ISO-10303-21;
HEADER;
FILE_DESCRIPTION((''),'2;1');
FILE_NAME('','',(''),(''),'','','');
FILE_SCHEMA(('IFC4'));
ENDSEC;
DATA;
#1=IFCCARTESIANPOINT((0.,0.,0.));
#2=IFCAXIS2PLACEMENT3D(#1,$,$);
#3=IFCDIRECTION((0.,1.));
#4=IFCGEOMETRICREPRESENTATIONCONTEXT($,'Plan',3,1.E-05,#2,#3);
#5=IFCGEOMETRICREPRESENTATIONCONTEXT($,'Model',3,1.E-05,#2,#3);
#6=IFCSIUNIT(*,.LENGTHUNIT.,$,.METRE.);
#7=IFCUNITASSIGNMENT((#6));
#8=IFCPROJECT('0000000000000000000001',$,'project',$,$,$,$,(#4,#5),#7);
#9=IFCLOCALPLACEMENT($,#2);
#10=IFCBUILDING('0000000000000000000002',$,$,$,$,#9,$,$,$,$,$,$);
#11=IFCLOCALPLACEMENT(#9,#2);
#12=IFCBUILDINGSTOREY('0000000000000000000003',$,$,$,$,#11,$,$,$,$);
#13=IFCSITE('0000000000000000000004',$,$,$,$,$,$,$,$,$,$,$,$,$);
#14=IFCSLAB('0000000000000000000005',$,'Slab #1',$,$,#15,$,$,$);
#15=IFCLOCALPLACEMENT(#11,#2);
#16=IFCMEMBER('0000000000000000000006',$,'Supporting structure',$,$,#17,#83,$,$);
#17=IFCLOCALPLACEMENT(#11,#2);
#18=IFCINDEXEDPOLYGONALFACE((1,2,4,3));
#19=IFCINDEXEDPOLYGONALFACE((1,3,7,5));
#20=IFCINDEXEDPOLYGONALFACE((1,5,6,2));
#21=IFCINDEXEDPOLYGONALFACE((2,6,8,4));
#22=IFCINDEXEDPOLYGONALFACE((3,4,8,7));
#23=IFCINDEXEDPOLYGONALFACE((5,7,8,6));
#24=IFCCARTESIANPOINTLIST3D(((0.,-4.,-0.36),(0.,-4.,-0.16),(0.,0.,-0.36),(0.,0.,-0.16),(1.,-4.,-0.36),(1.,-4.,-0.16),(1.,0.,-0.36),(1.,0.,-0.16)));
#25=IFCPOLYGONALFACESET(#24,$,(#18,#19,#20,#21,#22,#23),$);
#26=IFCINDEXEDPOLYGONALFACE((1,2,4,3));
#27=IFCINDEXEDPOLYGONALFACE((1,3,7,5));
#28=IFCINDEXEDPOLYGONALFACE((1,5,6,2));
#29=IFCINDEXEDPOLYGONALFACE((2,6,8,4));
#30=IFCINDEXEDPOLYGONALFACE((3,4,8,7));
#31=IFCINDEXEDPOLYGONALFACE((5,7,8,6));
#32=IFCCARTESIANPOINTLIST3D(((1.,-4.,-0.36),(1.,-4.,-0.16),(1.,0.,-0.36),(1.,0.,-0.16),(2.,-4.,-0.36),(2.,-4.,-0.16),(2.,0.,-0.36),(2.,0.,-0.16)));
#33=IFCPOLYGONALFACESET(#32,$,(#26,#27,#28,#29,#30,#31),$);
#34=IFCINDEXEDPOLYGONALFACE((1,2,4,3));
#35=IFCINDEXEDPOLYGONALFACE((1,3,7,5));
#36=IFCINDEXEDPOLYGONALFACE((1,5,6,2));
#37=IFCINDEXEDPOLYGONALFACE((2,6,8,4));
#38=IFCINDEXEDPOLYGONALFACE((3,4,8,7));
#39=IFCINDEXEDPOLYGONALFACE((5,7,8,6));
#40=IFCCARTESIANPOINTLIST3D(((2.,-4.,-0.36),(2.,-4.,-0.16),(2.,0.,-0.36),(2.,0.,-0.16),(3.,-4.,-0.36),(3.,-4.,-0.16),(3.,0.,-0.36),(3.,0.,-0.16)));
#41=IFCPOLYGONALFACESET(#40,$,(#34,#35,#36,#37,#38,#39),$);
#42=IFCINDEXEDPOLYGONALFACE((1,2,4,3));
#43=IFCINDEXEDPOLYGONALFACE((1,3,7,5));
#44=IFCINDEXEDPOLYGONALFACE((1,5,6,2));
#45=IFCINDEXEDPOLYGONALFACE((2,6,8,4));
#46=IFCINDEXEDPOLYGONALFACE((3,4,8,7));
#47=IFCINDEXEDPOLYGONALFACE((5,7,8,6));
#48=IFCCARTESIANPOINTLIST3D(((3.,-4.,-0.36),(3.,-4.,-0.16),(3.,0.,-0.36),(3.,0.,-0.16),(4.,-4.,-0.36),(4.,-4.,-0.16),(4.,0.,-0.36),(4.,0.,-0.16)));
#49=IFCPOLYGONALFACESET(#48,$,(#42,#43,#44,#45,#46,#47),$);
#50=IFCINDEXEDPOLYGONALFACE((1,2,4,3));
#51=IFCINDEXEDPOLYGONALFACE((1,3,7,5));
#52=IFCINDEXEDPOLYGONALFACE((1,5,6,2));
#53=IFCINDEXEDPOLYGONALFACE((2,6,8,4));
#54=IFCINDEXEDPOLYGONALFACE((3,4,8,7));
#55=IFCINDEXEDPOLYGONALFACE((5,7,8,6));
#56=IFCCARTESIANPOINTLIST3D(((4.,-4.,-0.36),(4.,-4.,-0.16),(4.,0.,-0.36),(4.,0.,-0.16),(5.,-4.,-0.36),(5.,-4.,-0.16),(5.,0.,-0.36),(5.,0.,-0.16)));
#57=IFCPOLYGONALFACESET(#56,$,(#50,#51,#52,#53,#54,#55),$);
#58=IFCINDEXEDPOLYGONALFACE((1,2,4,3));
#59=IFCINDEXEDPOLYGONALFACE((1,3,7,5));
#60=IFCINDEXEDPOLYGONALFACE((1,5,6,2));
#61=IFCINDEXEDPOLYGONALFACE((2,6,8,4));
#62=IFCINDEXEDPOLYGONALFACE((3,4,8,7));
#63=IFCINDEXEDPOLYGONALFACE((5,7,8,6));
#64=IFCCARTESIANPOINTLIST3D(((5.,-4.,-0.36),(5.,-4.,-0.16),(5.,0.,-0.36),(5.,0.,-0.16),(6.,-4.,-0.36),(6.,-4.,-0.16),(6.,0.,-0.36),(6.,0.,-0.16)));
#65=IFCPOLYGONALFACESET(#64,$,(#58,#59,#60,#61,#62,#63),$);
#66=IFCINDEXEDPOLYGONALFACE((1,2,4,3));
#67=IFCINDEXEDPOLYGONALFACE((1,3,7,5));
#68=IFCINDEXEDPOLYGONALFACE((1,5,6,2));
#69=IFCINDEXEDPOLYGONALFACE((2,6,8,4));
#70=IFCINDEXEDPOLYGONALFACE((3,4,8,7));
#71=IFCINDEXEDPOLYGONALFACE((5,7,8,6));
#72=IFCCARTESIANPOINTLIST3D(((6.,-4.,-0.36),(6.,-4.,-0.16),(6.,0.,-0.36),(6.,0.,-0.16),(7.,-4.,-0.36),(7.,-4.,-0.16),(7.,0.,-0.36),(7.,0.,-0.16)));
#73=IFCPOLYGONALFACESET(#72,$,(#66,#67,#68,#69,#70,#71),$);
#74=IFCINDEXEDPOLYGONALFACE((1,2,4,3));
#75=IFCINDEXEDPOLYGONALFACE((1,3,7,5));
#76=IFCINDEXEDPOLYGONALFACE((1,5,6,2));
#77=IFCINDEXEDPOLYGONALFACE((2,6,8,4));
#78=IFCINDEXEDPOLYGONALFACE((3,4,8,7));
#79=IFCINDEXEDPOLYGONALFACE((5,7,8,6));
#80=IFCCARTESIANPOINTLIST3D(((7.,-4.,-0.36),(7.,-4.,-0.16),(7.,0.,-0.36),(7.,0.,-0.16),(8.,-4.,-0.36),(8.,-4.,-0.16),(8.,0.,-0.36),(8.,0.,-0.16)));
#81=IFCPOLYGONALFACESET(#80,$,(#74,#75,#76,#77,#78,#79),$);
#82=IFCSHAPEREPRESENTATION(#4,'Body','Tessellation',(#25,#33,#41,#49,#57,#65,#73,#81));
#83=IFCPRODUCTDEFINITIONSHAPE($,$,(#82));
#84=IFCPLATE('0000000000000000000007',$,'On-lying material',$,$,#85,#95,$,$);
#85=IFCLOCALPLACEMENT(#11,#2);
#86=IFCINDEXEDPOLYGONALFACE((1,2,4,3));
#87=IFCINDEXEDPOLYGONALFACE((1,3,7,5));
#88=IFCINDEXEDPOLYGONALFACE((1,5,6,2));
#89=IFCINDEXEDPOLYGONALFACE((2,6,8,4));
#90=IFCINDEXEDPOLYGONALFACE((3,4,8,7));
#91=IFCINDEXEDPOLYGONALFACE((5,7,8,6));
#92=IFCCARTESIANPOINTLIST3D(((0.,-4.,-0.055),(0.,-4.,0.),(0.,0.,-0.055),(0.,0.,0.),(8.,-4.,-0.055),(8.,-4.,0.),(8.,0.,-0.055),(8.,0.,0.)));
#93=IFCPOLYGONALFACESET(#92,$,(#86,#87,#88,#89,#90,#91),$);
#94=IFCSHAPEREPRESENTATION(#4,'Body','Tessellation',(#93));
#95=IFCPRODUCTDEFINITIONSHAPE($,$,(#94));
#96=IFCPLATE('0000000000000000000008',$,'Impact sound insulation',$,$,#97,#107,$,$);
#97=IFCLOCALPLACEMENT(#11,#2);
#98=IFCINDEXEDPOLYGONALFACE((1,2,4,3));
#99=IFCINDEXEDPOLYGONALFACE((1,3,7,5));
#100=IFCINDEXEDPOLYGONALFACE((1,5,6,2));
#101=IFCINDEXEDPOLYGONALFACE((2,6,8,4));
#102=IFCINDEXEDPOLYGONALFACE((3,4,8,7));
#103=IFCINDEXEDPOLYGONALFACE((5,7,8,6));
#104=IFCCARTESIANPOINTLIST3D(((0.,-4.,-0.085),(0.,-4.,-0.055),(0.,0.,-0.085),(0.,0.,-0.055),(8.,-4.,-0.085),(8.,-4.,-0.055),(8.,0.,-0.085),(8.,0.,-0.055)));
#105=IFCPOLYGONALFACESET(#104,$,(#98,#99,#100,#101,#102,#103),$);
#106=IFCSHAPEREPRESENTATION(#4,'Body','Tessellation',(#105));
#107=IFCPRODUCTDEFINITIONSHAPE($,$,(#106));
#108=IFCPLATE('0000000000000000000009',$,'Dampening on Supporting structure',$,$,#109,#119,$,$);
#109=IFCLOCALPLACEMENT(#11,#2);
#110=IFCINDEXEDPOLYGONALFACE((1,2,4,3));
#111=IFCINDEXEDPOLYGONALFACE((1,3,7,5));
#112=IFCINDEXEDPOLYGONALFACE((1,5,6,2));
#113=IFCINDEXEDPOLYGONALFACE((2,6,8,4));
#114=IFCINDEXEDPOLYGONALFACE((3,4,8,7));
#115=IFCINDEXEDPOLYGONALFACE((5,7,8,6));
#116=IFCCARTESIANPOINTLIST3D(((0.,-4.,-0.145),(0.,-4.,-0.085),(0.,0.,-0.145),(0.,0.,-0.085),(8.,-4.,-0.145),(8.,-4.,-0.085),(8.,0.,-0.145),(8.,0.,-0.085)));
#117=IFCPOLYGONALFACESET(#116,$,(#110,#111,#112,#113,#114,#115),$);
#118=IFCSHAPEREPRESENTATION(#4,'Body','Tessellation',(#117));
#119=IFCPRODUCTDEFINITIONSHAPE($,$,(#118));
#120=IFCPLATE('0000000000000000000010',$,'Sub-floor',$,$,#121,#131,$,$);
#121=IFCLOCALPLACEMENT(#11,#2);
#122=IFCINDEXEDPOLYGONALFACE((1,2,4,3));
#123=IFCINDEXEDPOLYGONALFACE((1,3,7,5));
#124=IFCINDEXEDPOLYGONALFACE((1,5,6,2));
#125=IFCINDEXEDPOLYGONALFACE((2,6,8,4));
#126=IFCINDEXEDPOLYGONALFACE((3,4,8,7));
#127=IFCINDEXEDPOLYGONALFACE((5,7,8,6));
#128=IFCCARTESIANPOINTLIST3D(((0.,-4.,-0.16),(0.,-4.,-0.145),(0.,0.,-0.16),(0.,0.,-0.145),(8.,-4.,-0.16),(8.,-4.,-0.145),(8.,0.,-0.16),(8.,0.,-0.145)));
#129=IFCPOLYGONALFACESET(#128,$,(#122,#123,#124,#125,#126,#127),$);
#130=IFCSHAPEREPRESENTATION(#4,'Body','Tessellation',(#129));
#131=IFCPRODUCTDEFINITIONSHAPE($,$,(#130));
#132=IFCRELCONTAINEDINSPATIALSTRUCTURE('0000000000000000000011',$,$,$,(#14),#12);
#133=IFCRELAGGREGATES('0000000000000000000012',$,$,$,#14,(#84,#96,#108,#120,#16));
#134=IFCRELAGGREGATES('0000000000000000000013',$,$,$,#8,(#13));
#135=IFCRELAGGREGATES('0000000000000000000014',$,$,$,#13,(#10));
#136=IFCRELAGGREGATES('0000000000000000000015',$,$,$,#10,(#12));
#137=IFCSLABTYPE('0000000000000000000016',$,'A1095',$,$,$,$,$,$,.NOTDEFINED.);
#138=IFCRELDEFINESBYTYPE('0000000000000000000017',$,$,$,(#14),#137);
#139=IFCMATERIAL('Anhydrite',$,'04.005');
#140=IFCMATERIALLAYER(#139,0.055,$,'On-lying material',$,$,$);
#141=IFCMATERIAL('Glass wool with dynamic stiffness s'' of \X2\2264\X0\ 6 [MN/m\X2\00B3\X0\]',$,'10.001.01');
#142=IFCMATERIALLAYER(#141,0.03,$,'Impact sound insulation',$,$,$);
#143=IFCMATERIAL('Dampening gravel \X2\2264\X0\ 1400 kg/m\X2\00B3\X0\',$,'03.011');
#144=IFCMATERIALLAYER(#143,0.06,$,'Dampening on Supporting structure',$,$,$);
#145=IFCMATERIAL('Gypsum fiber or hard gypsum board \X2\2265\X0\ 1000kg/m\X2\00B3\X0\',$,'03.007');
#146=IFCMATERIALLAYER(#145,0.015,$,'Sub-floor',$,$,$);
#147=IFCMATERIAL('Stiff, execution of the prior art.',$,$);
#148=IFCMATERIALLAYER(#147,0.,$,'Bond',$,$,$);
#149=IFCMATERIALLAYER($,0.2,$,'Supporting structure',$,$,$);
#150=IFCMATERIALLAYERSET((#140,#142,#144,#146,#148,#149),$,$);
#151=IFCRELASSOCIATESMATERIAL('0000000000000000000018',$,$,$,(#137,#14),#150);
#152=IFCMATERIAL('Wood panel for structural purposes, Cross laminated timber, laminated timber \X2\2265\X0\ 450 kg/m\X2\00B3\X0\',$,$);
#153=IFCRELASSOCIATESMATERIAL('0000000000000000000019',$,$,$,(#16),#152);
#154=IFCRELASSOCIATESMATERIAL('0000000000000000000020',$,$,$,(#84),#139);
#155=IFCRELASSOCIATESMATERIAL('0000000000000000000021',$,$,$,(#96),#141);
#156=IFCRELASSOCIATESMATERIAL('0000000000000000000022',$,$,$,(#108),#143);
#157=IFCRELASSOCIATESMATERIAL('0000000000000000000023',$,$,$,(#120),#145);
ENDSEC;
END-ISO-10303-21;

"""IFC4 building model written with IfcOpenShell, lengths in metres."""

from ifc_helpers import new_model, si_unit, direction, frame, frame_2d, origin, origin_with_axes, place, context, project, spatial, rectangle, extrude, material, layer, layer_set, type_object, element, aggregate, save


model = new_model("IFC4")

# Units and contexts
plan_context = context("Plan", 3, precision=1e-05, world=origin(), true_north=direction((0.0, 1.0)))
model_context = context("Model", 3, precision=1e-05, world=origin(), true_north=direction((0.0, 1.0)))
ifc_project = project(units=[si_unit("LENGTHUNIT", "METRE")], contexts=[plan_context, model_context])

# Site, building, storey
site = spatial("IfcSite", under=ifc_project)
building_placement = place(None, origin())
building = spatial("IfcBuilding", under=site, at=building_placement)
storey_placement = place(building_placement, origin())
storey = spatial("IfcBuildingStorey", under=building, at=storey_placement)

# Slab, member, plates
ifc_material_1 = material(Name="Anhydrite", Category="04.005")
ifc_layer_1 = layer(ifc_material_1, 0.055, Name="On-lying material")
ifc_material_2 = material(Name="Glass wool with dynamic stiffness s' of ≤ 6 [MN/m³]", Category="10.001.01")
ifc_layer_2 = layer(ifc_material_2, 0.03, Name="Impact sound insulation")
ifc_material_3 = material(Name="Dampening gravel ≤ 1400 kg/m³", Category="03.011")
ifc_layer_3 = layer(ifc_material_3, 0.06, Name="Dampening on Supporting structure")
ifc_material_4 = material(Name="Gypsum fiber or hard gypsum board ≥ 1000kg/m³", Category="03.007")
ifc_layer_4 = layer(ifc_material_4, 0.015, Name="Sub-floor")
ifc_material_5 = material(Name="Stiff, execution of the prior art.")
ifc_layer_5 = layer(ifc_material_5, 0.0, Name="Bond")
ifc_layer_6 = layer(None, 0.2, Name="Supporting structure")
ifc_layer_set = layer_set([ifc_layer_1, ifc_layer_2, ifc_layer_3, ifc_layer_4, ifc_layer_5, ifc_layer_6])
slab_type = type_object("IfcSlabType", Name="A1095", PredefinedType="NOTDEFINED", material=ifc_layer_set)
slab_placement = place(None, frame((0.0, 0.0, 0.0), z_axis=(0.0, 0.0, -1.0), x_axis=(1.0, 0.0, 0.0)))
slab = element("IfcSlab", 1, at=slab_placement, inside=storey, type_object=slab_type, material=ifc_layer_set, Name="Slab #1")
ifc_material_6 = material(Name="Wood panel for structural purposes, Cross laminated timber, laminated timber ≥ 450 kg/m³")
member_placement = place(slab_placement, origin())
member = element("IfcMember", 2, at=member_placement, material=ifc_material_6, Name="Supporting structure", context=plan_context, shape_type="SweptSolid", body=[
    extrude(rectangle(XDim=1.0, YDim=0.2, at=frame_2d((0.5, 0.1), x_axis=(1.0, 0.0))), frame((0.0, 4.0, 0.16), z_axis=(0.0, -1.0, 0.0), x_axis=(1.0, 0.0, 0.0)), (0.0, 0.0, 1.0), 4.0),
    extrude(rectangle(XDim=1.0, YDim=0.2, at=frame_2d((0.5, 0.1), x_axis=(1.0, 0.0))), frame((1.0, 4.0, 0.16), z_axis=(0.0, -1.0, 0.0), x_axis=(1.0, 0.0, 0.0)), (0.0, 0.0, 1.0), 4.0),
    extrude(rectangle(XDim=1.0, YDim=0.2, at=frame_2d((0.5, 0.1), x_axis=(1.0, 0.0))), frame((2.0, 4.0, 0.16), z_axis=(0.0, -1.0, 0.0), x_axis=(1.0, 0.0, 0.0)), (0.0, 0.0, 1.0), 4.0),
    extrude(rectangle(XDim=1.0, YDim=0.2, at=frame_2d((0.5, 0.1), x_axis=(1.0, 0.0))), frame((3.0, 4.0, 0.16), z_axis=(0.0, -1.0, 0.0), x_axis=(1.0, 0.0, 0.0)), (0.0, 0.0, 1.0), 4.0),
    extrude(rectangle(XDim=1.0, YDim=0.2, at=frame_2d((0.5, 0.1), x_axis=(1.0, 0.0))), frame((4.0, 4.0, 0.16), z_axis=(0.0, -1.0, 0.0), x_axis=(1.0, 0.0, 0.0)), (0.0, 0.0, 1.0), 4.0),
    extrude(rectangle(XDim=1.0, YDim=0.2, at=frame_2d((0.5, 0.1), x_axis=(1.0, 0.0))), frame((5.0, 4.0, 0.16), z_axis=(0.0, -1.0, 0.0), x_axis=(1.0, 0.0, 0.0)), (0.0, 0.0, 1.0), 4.0),
    extrude(rectangle(XDim=1.0, YDim=0.2, at=frame_2d((0.5, 0.1), x_axis=(1.0, 0.0))), frame((6.0, 4.0, 0.16), z_axis=(0.0, -1.0, 0.0), x_axis=(1.0, 0.0, 0.0)), (0.0, 0.0, 1.0), 4.0),
    extrude(rectangle(XDim=1.0, YDim=0.2, at=frame_2d((0.5, 0.1), x_axis=(1.0, 0.0))), frame((7.0, 4.0, 0.16), z_axis=(0.0, -1.0, 0.0), x_axis=(1.0, 0.0, 0.0)), (0.0, 0.0, 1.0), 4.0),
])
plate_1_placement = place(slab_placement, origin())
plate_1 = element("IfcPlate", 3, at=plate_1_placement, material=ifc_material_1, Name="On-lying material", context=plan_context, shape_type="SweptSolid", body=[
    extrude(rectangle(XDim=8.0, YDim=4.0, at=frame_2d((4.0, 2.0), x_axis=(1.0, 0.0))), origin_with_axes(), (0.0, 0.0, 1.0), 0.055),
])
plate_2_placement = place(slab_placement, origin())
plate_2 = element("IfcPlate", 4, at=plate_2_placement, material=ifc_material_2, Name="Impact sound insulation", context=plan_context, shape_type="SweptSolid", body=[
    extrude(rectangle(XDim=8.0, YDim=4.0, at=frame_2d((4.0, 2.0), x_axis=(1.0, 0.0))), frame((0.0, 0.0, 0.055), z_axis=(0.0, 0.0, 1.0), x_axis=(1.0, 0.0, 0.0)), (0.0, 0.0, 1.0), 0.03),
])
plate_3_placement = place(slab_placement, origin())
plate_3 = element("IfcPlate", 5, at=plate_3_placement, material=ifc_material_3, Name="Dampening on Supporting structure", context=plan_context, shape_type="SweptSolid", body=[
    extrude(rectangle(XDim=8.0, YDim=4.0, at=frame_2d((4.0, 2.0), x_axis=(1.0, 0.0))), frame((0.0, 0.0, 0.085), z_axis=(0.0, 0.0, 1.0), x_axis=(1.0, 0.0, 0.0)), (0.0, 0.0, 1.0), 0.06),
])
plate_4_placement = place(slab_placement, origin())
plate_4 = element("IfcPlate", 6, at=plate_4_placement, material=ifc_material_4, Name="Sub-floor", context=plan_context, shape_type="SweptSolid", body=[
    extrude(rectangle(XDim=8.0, YDim=4.0, at=frame_2d((4.0, 2.0), x_axis=(1.0, 0.0))), frame((0.0, 0.0, 0.145), z_axis=(0.0, 0.0, 1.0), x_axis=(1.0, 0.0, 0.0)), (0.0, 0.0, 1.0), 0.015),
])
aggregate(slab, [plate_1, plate_2, plate_3, plate_4, member])

save(model, "model.ifc")
